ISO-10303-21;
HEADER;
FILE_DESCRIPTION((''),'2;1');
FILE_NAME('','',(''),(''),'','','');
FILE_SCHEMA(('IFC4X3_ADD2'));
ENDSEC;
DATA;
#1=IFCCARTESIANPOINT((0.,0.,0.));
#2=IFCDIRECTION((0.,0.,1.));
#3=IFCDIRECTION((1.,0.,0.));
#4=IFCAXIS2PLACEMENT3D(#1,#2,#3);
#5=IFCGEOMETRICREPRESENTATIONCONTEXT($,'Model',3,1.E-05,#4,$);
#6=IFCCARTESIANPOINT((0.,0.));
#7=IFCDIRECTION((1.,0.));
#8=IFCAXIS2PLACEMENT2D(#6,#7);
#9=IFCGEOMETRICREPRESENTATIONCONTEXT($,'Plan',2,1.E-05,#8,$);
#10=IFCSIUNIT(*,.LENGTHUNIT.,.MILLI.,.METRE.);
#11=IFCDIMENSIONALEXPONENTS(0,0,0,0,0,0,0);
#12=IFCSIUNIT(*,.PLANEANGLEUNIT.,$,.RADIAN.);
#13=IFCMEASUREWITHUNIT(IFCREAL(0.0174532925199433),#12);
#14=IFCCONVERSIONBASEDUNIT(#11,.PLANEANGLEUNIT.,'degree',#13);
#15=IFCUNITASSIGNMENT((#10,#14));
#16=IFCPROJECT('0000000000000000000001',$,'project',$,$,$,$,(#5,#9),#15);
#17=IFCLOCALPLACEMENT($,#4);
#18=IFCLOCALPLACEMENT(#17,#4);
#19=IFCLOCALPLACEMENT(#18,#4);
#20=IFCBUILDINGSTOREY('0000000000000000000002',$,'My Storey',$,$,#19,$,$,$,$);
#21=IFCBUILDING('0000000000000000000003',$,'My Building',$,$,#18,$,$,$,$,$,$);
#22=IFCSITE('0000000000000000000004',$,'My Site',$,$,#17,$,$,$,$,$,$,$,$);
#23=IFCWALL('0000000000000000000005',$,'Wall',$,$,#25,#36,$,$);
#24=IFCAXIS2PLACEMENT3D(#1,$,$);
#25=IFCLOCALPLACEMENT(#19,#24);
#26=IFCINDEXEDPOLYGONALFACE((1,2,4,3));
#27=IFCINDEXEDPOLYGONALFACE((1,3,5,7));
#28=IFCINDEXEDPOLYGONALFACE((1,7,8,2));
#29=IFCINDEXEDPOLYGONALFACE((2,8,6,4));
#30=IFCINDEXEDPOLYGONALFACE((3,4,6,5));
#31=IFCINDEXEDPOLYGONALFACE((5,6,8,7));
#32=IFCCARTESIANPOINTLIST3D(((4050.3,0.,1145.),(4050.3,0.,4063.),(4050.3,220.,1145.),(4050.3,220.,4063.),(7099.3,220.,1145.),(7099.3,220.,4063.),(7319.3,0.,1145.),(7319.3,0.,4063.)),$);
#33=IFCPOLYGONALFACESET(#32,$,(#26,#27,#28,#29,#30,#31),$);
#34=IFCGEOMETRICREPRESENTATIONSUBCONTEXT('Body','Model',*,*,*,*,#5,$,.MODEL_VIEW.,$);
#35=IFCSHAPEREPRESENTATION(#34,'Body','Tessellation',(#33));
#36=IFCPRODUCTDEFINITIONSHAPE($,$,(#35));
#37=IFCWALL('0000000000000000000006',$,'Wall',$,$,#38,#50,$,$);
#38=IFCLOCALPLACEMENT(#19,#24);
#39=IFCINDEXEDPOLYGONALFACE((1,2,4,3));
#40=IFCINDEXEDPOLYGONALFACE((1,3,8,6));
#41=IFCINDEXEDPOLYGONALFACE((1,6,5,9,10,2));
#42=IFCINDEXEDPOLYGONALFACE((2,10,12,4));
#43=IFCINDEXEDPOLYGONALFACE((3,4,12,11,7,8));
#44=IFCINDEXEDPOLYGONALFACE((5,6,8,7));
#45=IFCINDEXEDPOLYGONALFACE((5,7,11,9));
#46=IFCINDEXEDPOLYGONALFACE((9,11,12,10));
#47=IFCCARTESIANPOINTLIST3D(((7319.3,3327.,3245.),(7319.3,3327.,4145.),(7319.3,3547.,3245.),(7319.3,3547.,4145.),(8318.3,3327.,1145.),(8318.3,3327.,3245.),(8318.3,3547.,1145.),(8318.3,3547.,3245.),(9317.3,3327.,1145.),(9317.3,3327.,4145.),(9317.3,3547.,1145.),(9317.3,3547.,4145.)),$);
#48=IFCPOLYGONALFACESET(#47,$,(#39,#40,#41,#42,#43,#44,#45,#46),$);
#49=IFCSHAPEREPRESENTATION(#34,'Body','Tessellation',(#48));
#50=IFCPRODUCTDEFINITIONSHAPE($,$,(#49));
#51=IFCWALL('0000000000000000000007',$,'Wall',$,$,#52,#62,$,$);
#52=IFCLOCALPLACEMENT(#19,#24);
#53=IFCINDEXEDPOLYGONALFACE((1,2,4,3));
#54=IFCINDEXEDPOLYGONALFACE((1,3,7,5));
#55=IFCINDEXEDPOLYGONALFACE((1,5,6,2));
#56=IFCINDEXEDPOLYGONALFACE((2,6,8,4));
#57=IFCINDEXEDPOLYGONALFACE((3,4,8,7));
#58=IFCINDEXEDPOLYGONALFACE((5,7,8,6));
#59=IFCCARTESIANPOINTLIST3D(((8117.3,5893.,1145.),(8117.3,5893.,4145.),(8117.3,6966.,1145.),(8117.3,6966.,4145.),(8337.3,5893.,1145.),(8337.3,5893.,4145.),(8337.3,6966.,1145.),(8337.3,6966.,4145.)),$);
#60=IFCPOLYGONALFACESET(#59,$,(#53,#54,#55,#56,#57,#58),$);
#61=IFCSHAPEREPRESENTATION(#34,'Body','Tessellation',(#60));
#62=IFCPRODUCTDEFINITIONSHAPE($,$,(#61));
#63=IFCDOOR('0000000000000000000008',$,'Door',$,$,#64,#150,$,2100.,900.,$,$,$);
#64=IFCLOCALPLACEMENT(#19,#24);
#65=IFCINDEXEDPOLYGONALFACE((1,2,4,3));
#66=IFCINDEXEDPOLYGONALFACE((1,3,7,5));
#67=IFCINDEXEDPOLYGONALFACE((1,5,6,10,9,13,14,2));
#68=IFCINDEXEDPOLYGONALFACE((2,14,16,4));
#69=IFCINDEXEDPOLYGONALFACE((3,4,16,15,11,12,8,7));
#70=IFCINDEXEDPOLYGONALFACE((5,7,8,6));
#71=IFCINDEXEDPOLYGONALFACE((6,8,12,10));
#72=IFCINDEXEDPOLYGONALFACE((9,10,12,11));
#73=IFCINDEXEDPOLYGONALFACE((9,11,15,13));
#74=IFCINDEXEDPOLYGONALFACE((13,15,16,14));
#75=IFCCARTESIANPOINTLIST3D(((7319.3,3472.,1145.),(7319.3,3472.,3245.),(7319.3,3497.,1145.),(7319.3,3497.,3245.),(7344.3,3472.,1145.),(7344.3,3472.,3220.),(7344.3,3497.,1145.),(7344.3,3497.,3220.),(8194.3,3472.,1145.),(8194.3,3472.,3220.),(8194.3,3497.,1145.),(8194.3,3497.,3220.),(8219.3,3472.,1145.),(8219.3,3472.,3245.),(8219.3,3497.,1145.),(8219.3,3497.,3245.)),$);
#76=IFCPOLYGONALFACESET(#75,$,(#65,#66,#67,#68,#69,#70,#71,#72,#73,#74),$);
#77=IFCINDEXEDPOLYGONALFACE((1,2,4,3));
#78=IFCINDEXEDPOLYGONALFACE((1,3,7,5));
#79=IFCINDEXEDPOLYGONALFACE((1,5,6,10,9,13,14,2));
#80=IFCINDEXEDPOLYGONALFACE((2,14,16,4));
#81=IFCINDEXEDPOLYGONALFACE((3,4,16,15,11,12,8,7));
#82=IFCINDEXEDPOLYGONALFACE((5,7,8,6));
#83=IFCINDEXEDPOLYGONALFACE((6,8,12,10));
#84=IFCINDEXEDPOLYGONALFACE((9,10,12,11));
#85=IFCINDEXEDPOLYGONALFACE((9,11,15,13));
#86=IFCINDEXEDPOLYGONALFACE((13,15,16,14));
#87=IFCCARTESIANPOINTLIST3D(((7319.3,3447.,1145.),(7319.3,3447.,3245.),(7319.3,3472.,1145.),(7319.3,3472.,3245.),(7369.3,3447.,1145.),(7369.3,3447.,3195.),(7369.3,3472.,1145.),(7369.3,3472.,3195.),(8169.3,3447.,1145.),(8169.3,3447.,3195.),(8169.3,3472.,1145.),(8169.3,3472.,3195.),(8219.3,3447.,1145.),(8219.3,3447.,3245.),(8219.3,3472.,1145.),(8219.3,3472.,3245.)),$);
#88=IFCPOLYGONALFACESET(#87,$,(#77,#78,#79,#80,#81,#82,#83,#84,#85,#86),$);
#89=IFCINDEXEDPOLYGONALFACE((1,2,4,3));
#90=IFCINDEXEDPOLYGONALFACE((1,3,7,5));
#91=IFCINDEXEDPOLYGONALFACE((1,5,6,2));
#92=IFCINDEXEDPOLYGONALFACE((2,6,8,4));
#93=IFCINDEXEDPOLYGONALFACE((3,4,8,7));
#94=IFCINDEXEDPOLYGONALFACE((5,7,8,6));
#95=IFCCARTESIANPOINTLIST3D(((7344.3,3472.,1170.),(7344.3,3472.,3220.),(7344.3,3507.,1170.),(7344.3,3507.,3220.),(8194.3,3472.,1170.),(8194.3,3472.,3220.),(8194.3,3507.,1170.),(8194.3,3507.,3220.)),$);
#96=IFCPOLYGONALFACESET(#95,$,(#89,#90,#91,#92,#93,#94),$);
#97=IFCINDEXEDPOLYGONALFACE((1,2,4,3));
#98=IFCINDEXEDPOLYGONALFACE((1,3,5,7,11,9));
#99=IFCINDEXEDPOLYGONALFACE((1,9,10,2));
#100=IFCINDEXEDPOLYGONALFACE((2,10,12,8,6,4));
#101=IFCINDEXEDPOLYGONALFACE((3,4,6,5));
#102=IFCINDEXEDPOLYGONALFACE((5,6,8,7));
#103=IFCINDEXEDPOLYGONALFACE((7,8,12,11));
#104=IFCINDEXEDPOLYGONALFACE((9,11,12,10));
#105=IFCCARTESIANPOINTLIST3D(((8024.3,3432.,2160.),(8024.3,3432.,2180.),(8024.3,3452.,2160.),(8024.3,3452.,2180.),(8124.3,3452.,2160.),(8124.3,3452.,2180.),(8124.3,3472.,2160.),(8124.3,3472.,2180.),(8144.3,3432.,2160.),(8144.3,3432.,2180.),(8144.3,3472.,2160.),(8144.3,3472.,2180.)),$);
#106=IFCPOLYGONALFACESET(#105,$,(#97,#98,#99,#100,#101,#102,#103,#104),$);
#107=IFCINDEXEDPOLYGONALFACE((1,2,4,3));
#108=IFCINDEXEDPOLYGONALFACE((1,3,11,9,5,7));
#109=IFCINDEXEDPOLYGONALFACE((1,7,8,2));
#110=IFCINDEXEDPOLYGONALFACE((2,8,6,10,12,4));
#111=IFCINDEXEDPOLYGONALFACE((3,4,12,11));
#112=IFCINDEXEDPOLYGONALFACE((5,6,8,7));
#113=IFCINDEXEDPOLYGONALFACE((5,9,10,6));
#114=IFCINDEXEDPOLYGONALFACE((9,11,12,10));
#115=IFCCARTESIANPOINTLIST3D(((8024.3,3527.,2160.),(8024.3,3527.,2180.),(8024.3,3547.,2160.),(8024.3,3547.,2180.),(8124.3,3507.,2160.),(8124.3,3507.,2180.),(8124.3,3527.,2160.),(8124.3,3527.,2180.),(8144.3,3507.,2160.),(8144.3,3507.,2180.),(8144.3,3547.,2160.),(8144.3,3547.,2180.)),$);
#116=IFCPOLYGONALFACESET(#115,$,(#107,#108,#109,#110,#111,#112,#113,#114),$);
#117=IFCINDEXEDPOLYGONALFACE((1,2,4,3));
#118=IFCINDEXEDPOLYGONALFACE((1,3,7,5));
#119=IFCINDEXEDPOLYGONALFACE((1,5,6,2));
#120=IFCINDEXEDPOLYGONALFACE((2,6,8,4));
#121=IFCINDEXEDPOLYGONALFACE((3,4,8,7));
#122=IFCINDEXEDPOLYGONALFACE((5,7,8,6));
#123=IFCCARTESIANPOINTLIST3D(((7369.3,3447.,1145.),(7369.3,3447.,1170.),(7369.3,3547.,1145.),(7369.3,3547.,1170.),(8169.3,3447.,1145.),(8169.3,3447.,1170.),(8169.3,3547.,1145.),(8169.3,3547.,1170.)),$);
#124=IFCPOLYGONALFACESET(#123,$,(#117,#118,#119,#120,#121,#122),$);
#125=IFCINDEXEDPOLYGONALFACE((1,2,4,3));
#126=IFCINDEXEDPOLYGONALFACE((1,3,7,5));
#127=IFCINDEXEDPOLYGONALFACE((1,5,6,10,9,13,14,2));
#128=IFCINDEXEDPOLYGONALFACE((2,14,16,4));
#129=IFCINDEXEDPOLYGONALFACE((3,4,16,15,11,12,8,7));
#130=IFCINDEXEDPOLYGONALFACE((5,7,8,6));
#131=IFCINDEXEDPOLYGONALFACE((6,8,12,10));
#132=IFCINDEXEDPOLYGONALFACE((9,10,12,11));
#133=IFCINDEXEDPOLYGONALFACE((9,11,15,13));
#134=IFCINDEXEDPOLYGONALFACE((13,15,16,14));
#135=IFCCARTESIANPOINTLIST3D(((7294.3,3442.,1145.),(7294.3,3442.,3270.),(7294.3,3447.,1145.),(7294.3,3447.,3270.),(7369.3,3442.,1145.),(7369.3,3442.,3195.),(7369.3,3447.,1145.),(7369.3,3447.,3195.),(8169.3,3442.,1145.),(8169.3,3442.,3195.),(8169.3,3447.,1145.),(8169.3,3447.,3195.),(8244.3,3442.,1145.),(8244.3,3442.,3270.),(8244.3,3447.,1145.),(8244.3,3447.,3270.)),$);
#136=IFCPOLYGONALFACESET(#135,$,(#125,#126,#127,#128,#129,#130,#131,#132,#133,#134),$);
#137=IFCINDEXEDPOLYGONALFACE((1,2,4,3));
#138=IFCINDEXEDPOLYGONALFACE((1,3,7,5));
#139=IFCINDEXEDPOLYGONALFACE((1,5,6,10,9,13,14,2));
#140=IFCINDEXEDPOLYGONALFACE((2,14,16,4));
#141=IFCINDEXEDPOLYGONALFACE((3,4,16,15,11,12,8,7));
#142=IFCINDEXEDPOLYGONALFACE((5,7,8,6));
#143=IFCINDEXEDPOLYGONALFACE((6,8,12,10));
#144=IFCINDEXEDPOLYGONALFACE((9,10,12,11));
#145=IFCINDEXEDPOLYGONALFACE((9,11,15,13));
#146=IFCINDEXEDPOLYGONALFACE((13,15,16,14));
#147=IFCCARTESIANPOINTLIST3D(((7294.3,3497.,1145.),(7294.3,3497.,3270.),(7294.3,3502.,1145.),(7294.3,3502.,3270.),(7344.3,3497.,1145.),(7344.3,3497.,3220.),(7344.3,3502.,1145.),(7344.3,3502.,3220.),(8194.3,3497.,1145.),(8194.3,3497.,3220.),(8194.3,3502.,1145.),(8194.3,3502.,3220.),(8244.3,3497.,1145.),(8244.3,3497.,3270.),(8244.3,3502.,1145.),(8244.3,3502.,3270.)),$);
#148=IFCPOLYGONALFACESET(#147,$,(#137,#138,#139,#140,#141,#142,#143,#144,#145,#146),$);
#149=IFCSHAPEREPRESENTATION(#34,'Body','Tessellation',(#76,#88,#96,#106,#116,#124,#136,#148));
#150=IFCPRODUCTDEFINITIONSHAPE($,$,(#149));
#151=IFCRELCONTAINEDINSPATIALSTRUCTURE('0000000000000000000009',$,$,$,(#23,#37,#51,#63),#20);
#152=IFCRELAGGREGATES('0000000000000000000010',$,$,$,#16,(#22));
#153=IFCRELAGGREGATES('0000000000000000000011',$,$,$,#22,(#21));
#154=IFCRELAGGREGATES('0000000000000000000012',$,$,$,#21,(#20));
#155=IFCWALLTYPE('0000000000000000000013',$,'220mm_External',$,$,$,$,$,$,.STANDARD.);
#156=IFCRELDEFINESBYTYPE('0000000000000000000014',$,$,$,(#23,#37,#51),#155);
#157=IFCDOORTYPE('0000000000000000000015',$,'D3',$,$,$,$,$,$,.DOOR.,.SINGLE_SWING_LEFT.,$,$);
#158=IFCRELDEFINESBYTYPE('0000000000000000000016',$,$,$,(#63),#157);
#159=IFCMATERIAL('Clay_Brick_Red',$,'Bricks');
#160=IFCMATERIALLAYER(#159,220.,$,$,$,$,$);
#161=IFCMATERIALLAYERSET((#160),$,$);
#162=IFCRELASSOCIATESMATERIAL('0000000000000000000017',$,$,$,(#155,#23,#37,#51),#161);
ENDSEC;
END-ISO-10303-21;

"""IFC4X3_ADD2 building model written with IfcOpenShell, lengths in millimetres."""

from ifc_helpers import new_model, entity, si_unit, converted_unit, frame, origin_with_axes, origin_2d_with_axis, place, context, subcontext, project, spatial, line, indexed_curve, outline, extrude, shape, source, transform, mapped, material, layer, layer_set, layer_usage, type_object, type_shapes, element, save


model = new_model("IFC4X3_ADD2")

# Units and contexts
model_context = context("Model", 3, precision=1e-05, world=origin_with_axes())
plan_context = context("Plan", 2, precision=1e-05, world=origin_2d_with_axis())
body_context_1 = subcontext(model_context, "Body", "Model", "MODEL_VIEW")
body_context_2 = subcontext(plan_context, "Body", "Plan", "PLAN_VIEW")
ifc_project = project(units=[si_unit("LENGTHUNIT", "METRE", prefix="MILLI"), converted_unit("PLANEANGLEUNIT", "degree", entity("IfcReal", 0.0174532925199433), si_unit("PLANEANGLEUNIT", "RADIAN"), dimensions=[0, 0, 0, 0, 0, 0, 0])], contexts=[model_context, plan_context])

# Site, building, storey
site_placement = place(None, origin_with_axes())
site = spatial("IfcSite", under=ifc_project, at=site_placement, Name="My Site")
building_placement = place(site_placement, origin_with_axes())
building = spatial("IfcBuilding", under=site, at=building_placement, Name="My Building")
storey_placement = place(building_placement, origin_with_axes())
storey = spatial("IfcBuildingStorey", under=building, at=storey_placement, Name="My Storey")

# Wall
ifc_material_1 = material(Name="Clay_Brick_Red", Category="Bricks")
ifc_layer_1 = layer(ifc_material_1, 220.0)
ifc_layer_set_1 = layer_set([ifc_layer_1])
ifc_layer_usage_1 = layer_usage(ifc_layer_set_1, "AXIS2", "POSITIVE", 0.0)
wall_type_1 = type_object("IfcWallType", Name="220mm_External", PredefinedType="STANDARD", material=ifc_layer_set_1)
wall_1_placement = place(storey_placement, frame((7099.3, 220.0, 1145.0), z_axis=(0.0, 0.0, 1.0), x_axis=(-1.0, 0.0, 0.0)))
element("IfcWall", 1, at=wall_1_placement, inside=storey, type_object=wall_type_1, material=ifc_layer_usage_1, Name="Wall", context=body_context_1, shape_type="SweptSolid", body=[
    extrude(outline(indexed_curve([(0.0, 0.0), (-220.0, 220.0), (3049.0, 220.0), (3049.0, 0.0)], segments=[line(1, 2, 3, 4, 1)])), origin_with_axes(), (0.0, 0.0, 1.0), 2918.0),
])

# Wall, opening
ifc_layer_usage_2 = layer_usage(ifc_layer_set_1, "AXIS2", "POSITIVE", 0.0)
wall_2_placement = place(storey_placement, frame((7319.3, 3327.0, 1145.0), z_axis=(0.0, 0.0, 1.0), x_axis=(1.0, 0.0, 0.0)))
wall_2 = element("IfcWall", 2, at=wall_2_placement, inside=storey, type_object=wall_type_1, material=ifc_layer_usage_2, Name="Wall", context=body_context_1, shape_type="SweptSolid", body=[
    extrude(outline(indexed_curve([(0.0, 0.0), (0.0, 220.0), (1998.0, 220.0), (1998.0, 0.0)], segments=[line(1, 2, 3, 4, 1)])), origin_with_axes(), (0.0, 0.0, 1.0), 3000.0),
])
opening_1_placement = place(wall_2_placement, frame((0.0, -200.0, 0.0), z_axis=(0.0, 0.0, 1.0), x_axis=(1.0, 0.0, 0.0)))
element("IfcOpeningElement", 3, at=opening_1_placement, cuts=wall_2, PredefinedType="OPENING", context=body_context_1, shape_type="SweptSolid", body=[
    extrude(outline(indexed_curve([(0.0, 0.0), (999.0, 0.0), (999.0, 500.0), (0.0, 500.0), (0.0, 0.0)])), origin_with_axes(), (0.0, 0.0, 1.0), 2100.0),
])

# Wall
ifc_layer_usage_3 = layer_usage(ifc_layer_set_1, "AXIS2", "POSITIVE", 0.0)
wall_3_placement = place(storey_placement, frame((8117.3, 6966.0, 1145.0), z_axis=(0.0, 0.0, 1.0), x_axis=(0.000001, -1.0, 0.0)))
element("IfcWall", 4, at=wall_3_placement, inside=storey, type_object=wall_type_1, material=ifc_layer_usage_3, Name="Wall", context=body_context_1, shape_type="SweptSolid", body=[
    extrude(outline(indexed_curve([(0.0, 0.0), (0.0, 220.0), (1073.0, 220.0), (1073.0, 0.0)], segments=[line(1, 2, 3, 4, 1)])), origin_with_axes(), (0.0, 0.0, 1.0), 3000.0),
])

# Door
door_type = type_object("IfcDoorType", Name="D3", OperationType="SINGLE_SWING_LEFT", PredefinedType="DOOR")
shared_shape_1 = source(origin_with_axes(), body_context_1, "Body", "SweptSolid", [
    extrude(outline(indexed_curve([(0.0, 0.0), (0.0, 2100.0), (900.0, 2100.0), (900.0, 0.0), (875.0, 0.0), (875.0, 2075.0), (25.0, 2075.0), (25.0, 0.0)], segments=[line(1, 2, 3, 4, 5, 6, 7, 8, 1)])), frame((0.0, 25.0, 0.0), z_axis=(0.0, -1.0, 0.0), x_axis=(1.0, 0.0, 0.0)), (0.0, 0.0, -1.0), 25.0),
    extrude(outline(indexed_curve([(0.0, 0.0), (0.0, 2100.0), (900.0, 2100.0), (900.0, 0.0), (850.0, 0.0), (850.0, 2050.0), (50.0, 2050.0), (50.0, 0.0)], segments=[line(1, 2, 3, 4, 5, 6, 7, 8, 1)])), frame((0.0, 0.0, 0.0), z_axis=(0.0, -1.0, 0.0), x_axis=(1.0, 0.0, 0.0)), (0.0, 0.0, -1.0), 25.0),
    extrude(outline(indexed_curve([(0.0, 0.0), (850.0, 0.0), (850.0, 35.0), (0.0, 35.0)], segments=[line(1, 2, 3, 4, 1)])), frame((25.0, 25.0, 25.0), z_axis=(0.0, 0.0, 1.0), x_axis=(1.0, 0.0, 0.0)), (0.0, 0.0, 1.0), 2050.0),
    extrude(outline(indexed_curve([(0.0, 0.0), (0.0, -40.0), (-120.0, -40.0), (-120.0, -20.0), (-20.0, -20.0), (-20.0, 0.0)], segments=[line(1, 2, 3, 4, 5, 6, 1)])), frame((825.0, 25.0, 1015.0), z_axis=(0.0, 0.0, 1.0), x_axis=(1.0, 0.0, 0.0)), (0.0, 0.0, 1.0), 20.0),
    extrude(outline(indexed_curve([(0.0, 0.0), (0.0, 40.0), (-120.0, 40.0), (-120.0, 20.0), (-20.0, 20.0), (-20.0, 0.0)], segments=[line(1, 2, 3, 4, 5, 6, 1)])), frame((825.0, 60.0, 1015.0), z_axis=(0.0, 0.0, 1.0), x_axis=(1.0, 0.0, 0.0)), (0.0, 0.0, 1.0), 20.0),
    extrude(outline(indexed_curve([(0.0, 0.0), (800.0, 0.0), (800.0, 100.0), (0.0, 100.0)], segments=[line(1, 2, 3, 4, 1)])), frame((50.0, 0.0, 0.0), z_axis=(0.0, 0.0, 1.0), x_axis=(1.0, 0.0, 0.0)), (0.0, 0.0, 1.0), 25.0),
    extrude(outline(indexed_curve([(0.0, 0.0), (0.0, 2125.0), (950.0, 2125.0), (950.0, 0.0), (875.0, 0.0), (875.0, 2050.0), (75.0, 2050.0), (75.0, 0.0)], segments=[line(1, 2, 3, 4, 5, 6, 7, 8, 1)])), frame((-25.0, -5.0, 0.0), z_axis=(0.0, -1.0, 0.0), x_axis=(1.0, 0.0, 0.0)), (0.0, 0.0, -1.0), 5.0),
    extrude(outline(indexed_curve([(0.0, 0.0), (0.0, 2125.0), (950.0, 2125.0), (950.0, 0.0), (900.0, 0.0), (900.0, 2075.0), (50.0, 2075.0), (50.0, 0.0)], segments=[line(1, 2, 3, 4, 5, 6, 7, 8, 1)])), frame((-25.0, 50.0, 0.0), z_axis=(0.0, -1.0, 0.0), x_axis=(1.0, 0.0, 0.0)), (0.0, 0.0, -1.0), 5.0),
])
shared_shape_2 = source(origin_with_axes(), body_context_2, "Body", "Curve2D", [
    entity("IfcIndexedPolyCurve", entity("IfcCartesianPointList2D", [[0.0, 0.0], [0.0, 50.0], [25.0, 50.0], [25.0, 25.0], [50.0, 25.0], [50.0, 0.0]]), [entity("IfcLineIndex", [1, 2, 3, 4, 5, 6, 1])]),
    entity("IfcIndexedPolyCurve", entity("IfcCartesianPointList2D", [[900.0, 0.0], [900.0, 50.0], [875.0, 50.0], [875.0, 25.0], [850.0, 25.0], [850.0, 0.0]]), [entity("IfcLineIndex", [1, 2, 3, 4, 5, 6, 1])]),
    entity("IfcTrimmedCurve", entity("IfcEllipse", entity("IfcAxis2Placement2D", entity("IfcCartesianPoint", [60.0, 50.0]), entity("IfcDirection", [1.0, 0.0])), 815.0, 850.0), [entity("IfcCartesianPoint", [875.0, 50.0])], [entity("IfcCartesianPoint", [60.0, 900.0])], True, "CARTESIAN"),
    entity("IfcIndexedPolyCurve", entity("IfcCartesianPointList2D", [[25.0, 50.0], [60.0, 50.0], [60.0, 900.0], [25.0, 900.0]]), [entity("IfcLineIndex", [1, 2, 3, 4, 1])]),
])
type_shapes(door_type, [shared_shape_1, shared_shape_2])
for number, where, z_axis, x_axis, name in (
    (5, (7319.3, 3447.0, 1145.0), (0.0, 0.0, 1.0), (1.0, 0.0, 0.0), "Door"),
):
    element("IfcDoor", number, at=place(storey_placement, frame(where, z_axis=z_axis, x_axis=x_axis)), inside=storey, type_object=door_type, Name=name, OverallHeight=2100.0, OverallWidth=900.0, shapes=[
        shape(body_context_1, "Body", "MappedRepresentation", [mapped(shared_shape_1, transform((0.0, 0.0, 0.0), x_axis=(1.0, 0.0, 0.0), y_axis=(0.0, 1.0, 0.0), z_axis=(0.0, 0.0, 1.0), scale=1.0))]),
        shape(body_context_2, "Body", "MappedRepresentation", [mapped(shared_shape_2, transform((0.0, 0.0, 0.0), x_axis=(1.0, 0.0, 0.0), y_axis=(0.0, 1.0, 0.0), z_axis=(0.0, 0.0, 1.0), scale=1.0))]),
    ])

save(model, "model.ifc")
